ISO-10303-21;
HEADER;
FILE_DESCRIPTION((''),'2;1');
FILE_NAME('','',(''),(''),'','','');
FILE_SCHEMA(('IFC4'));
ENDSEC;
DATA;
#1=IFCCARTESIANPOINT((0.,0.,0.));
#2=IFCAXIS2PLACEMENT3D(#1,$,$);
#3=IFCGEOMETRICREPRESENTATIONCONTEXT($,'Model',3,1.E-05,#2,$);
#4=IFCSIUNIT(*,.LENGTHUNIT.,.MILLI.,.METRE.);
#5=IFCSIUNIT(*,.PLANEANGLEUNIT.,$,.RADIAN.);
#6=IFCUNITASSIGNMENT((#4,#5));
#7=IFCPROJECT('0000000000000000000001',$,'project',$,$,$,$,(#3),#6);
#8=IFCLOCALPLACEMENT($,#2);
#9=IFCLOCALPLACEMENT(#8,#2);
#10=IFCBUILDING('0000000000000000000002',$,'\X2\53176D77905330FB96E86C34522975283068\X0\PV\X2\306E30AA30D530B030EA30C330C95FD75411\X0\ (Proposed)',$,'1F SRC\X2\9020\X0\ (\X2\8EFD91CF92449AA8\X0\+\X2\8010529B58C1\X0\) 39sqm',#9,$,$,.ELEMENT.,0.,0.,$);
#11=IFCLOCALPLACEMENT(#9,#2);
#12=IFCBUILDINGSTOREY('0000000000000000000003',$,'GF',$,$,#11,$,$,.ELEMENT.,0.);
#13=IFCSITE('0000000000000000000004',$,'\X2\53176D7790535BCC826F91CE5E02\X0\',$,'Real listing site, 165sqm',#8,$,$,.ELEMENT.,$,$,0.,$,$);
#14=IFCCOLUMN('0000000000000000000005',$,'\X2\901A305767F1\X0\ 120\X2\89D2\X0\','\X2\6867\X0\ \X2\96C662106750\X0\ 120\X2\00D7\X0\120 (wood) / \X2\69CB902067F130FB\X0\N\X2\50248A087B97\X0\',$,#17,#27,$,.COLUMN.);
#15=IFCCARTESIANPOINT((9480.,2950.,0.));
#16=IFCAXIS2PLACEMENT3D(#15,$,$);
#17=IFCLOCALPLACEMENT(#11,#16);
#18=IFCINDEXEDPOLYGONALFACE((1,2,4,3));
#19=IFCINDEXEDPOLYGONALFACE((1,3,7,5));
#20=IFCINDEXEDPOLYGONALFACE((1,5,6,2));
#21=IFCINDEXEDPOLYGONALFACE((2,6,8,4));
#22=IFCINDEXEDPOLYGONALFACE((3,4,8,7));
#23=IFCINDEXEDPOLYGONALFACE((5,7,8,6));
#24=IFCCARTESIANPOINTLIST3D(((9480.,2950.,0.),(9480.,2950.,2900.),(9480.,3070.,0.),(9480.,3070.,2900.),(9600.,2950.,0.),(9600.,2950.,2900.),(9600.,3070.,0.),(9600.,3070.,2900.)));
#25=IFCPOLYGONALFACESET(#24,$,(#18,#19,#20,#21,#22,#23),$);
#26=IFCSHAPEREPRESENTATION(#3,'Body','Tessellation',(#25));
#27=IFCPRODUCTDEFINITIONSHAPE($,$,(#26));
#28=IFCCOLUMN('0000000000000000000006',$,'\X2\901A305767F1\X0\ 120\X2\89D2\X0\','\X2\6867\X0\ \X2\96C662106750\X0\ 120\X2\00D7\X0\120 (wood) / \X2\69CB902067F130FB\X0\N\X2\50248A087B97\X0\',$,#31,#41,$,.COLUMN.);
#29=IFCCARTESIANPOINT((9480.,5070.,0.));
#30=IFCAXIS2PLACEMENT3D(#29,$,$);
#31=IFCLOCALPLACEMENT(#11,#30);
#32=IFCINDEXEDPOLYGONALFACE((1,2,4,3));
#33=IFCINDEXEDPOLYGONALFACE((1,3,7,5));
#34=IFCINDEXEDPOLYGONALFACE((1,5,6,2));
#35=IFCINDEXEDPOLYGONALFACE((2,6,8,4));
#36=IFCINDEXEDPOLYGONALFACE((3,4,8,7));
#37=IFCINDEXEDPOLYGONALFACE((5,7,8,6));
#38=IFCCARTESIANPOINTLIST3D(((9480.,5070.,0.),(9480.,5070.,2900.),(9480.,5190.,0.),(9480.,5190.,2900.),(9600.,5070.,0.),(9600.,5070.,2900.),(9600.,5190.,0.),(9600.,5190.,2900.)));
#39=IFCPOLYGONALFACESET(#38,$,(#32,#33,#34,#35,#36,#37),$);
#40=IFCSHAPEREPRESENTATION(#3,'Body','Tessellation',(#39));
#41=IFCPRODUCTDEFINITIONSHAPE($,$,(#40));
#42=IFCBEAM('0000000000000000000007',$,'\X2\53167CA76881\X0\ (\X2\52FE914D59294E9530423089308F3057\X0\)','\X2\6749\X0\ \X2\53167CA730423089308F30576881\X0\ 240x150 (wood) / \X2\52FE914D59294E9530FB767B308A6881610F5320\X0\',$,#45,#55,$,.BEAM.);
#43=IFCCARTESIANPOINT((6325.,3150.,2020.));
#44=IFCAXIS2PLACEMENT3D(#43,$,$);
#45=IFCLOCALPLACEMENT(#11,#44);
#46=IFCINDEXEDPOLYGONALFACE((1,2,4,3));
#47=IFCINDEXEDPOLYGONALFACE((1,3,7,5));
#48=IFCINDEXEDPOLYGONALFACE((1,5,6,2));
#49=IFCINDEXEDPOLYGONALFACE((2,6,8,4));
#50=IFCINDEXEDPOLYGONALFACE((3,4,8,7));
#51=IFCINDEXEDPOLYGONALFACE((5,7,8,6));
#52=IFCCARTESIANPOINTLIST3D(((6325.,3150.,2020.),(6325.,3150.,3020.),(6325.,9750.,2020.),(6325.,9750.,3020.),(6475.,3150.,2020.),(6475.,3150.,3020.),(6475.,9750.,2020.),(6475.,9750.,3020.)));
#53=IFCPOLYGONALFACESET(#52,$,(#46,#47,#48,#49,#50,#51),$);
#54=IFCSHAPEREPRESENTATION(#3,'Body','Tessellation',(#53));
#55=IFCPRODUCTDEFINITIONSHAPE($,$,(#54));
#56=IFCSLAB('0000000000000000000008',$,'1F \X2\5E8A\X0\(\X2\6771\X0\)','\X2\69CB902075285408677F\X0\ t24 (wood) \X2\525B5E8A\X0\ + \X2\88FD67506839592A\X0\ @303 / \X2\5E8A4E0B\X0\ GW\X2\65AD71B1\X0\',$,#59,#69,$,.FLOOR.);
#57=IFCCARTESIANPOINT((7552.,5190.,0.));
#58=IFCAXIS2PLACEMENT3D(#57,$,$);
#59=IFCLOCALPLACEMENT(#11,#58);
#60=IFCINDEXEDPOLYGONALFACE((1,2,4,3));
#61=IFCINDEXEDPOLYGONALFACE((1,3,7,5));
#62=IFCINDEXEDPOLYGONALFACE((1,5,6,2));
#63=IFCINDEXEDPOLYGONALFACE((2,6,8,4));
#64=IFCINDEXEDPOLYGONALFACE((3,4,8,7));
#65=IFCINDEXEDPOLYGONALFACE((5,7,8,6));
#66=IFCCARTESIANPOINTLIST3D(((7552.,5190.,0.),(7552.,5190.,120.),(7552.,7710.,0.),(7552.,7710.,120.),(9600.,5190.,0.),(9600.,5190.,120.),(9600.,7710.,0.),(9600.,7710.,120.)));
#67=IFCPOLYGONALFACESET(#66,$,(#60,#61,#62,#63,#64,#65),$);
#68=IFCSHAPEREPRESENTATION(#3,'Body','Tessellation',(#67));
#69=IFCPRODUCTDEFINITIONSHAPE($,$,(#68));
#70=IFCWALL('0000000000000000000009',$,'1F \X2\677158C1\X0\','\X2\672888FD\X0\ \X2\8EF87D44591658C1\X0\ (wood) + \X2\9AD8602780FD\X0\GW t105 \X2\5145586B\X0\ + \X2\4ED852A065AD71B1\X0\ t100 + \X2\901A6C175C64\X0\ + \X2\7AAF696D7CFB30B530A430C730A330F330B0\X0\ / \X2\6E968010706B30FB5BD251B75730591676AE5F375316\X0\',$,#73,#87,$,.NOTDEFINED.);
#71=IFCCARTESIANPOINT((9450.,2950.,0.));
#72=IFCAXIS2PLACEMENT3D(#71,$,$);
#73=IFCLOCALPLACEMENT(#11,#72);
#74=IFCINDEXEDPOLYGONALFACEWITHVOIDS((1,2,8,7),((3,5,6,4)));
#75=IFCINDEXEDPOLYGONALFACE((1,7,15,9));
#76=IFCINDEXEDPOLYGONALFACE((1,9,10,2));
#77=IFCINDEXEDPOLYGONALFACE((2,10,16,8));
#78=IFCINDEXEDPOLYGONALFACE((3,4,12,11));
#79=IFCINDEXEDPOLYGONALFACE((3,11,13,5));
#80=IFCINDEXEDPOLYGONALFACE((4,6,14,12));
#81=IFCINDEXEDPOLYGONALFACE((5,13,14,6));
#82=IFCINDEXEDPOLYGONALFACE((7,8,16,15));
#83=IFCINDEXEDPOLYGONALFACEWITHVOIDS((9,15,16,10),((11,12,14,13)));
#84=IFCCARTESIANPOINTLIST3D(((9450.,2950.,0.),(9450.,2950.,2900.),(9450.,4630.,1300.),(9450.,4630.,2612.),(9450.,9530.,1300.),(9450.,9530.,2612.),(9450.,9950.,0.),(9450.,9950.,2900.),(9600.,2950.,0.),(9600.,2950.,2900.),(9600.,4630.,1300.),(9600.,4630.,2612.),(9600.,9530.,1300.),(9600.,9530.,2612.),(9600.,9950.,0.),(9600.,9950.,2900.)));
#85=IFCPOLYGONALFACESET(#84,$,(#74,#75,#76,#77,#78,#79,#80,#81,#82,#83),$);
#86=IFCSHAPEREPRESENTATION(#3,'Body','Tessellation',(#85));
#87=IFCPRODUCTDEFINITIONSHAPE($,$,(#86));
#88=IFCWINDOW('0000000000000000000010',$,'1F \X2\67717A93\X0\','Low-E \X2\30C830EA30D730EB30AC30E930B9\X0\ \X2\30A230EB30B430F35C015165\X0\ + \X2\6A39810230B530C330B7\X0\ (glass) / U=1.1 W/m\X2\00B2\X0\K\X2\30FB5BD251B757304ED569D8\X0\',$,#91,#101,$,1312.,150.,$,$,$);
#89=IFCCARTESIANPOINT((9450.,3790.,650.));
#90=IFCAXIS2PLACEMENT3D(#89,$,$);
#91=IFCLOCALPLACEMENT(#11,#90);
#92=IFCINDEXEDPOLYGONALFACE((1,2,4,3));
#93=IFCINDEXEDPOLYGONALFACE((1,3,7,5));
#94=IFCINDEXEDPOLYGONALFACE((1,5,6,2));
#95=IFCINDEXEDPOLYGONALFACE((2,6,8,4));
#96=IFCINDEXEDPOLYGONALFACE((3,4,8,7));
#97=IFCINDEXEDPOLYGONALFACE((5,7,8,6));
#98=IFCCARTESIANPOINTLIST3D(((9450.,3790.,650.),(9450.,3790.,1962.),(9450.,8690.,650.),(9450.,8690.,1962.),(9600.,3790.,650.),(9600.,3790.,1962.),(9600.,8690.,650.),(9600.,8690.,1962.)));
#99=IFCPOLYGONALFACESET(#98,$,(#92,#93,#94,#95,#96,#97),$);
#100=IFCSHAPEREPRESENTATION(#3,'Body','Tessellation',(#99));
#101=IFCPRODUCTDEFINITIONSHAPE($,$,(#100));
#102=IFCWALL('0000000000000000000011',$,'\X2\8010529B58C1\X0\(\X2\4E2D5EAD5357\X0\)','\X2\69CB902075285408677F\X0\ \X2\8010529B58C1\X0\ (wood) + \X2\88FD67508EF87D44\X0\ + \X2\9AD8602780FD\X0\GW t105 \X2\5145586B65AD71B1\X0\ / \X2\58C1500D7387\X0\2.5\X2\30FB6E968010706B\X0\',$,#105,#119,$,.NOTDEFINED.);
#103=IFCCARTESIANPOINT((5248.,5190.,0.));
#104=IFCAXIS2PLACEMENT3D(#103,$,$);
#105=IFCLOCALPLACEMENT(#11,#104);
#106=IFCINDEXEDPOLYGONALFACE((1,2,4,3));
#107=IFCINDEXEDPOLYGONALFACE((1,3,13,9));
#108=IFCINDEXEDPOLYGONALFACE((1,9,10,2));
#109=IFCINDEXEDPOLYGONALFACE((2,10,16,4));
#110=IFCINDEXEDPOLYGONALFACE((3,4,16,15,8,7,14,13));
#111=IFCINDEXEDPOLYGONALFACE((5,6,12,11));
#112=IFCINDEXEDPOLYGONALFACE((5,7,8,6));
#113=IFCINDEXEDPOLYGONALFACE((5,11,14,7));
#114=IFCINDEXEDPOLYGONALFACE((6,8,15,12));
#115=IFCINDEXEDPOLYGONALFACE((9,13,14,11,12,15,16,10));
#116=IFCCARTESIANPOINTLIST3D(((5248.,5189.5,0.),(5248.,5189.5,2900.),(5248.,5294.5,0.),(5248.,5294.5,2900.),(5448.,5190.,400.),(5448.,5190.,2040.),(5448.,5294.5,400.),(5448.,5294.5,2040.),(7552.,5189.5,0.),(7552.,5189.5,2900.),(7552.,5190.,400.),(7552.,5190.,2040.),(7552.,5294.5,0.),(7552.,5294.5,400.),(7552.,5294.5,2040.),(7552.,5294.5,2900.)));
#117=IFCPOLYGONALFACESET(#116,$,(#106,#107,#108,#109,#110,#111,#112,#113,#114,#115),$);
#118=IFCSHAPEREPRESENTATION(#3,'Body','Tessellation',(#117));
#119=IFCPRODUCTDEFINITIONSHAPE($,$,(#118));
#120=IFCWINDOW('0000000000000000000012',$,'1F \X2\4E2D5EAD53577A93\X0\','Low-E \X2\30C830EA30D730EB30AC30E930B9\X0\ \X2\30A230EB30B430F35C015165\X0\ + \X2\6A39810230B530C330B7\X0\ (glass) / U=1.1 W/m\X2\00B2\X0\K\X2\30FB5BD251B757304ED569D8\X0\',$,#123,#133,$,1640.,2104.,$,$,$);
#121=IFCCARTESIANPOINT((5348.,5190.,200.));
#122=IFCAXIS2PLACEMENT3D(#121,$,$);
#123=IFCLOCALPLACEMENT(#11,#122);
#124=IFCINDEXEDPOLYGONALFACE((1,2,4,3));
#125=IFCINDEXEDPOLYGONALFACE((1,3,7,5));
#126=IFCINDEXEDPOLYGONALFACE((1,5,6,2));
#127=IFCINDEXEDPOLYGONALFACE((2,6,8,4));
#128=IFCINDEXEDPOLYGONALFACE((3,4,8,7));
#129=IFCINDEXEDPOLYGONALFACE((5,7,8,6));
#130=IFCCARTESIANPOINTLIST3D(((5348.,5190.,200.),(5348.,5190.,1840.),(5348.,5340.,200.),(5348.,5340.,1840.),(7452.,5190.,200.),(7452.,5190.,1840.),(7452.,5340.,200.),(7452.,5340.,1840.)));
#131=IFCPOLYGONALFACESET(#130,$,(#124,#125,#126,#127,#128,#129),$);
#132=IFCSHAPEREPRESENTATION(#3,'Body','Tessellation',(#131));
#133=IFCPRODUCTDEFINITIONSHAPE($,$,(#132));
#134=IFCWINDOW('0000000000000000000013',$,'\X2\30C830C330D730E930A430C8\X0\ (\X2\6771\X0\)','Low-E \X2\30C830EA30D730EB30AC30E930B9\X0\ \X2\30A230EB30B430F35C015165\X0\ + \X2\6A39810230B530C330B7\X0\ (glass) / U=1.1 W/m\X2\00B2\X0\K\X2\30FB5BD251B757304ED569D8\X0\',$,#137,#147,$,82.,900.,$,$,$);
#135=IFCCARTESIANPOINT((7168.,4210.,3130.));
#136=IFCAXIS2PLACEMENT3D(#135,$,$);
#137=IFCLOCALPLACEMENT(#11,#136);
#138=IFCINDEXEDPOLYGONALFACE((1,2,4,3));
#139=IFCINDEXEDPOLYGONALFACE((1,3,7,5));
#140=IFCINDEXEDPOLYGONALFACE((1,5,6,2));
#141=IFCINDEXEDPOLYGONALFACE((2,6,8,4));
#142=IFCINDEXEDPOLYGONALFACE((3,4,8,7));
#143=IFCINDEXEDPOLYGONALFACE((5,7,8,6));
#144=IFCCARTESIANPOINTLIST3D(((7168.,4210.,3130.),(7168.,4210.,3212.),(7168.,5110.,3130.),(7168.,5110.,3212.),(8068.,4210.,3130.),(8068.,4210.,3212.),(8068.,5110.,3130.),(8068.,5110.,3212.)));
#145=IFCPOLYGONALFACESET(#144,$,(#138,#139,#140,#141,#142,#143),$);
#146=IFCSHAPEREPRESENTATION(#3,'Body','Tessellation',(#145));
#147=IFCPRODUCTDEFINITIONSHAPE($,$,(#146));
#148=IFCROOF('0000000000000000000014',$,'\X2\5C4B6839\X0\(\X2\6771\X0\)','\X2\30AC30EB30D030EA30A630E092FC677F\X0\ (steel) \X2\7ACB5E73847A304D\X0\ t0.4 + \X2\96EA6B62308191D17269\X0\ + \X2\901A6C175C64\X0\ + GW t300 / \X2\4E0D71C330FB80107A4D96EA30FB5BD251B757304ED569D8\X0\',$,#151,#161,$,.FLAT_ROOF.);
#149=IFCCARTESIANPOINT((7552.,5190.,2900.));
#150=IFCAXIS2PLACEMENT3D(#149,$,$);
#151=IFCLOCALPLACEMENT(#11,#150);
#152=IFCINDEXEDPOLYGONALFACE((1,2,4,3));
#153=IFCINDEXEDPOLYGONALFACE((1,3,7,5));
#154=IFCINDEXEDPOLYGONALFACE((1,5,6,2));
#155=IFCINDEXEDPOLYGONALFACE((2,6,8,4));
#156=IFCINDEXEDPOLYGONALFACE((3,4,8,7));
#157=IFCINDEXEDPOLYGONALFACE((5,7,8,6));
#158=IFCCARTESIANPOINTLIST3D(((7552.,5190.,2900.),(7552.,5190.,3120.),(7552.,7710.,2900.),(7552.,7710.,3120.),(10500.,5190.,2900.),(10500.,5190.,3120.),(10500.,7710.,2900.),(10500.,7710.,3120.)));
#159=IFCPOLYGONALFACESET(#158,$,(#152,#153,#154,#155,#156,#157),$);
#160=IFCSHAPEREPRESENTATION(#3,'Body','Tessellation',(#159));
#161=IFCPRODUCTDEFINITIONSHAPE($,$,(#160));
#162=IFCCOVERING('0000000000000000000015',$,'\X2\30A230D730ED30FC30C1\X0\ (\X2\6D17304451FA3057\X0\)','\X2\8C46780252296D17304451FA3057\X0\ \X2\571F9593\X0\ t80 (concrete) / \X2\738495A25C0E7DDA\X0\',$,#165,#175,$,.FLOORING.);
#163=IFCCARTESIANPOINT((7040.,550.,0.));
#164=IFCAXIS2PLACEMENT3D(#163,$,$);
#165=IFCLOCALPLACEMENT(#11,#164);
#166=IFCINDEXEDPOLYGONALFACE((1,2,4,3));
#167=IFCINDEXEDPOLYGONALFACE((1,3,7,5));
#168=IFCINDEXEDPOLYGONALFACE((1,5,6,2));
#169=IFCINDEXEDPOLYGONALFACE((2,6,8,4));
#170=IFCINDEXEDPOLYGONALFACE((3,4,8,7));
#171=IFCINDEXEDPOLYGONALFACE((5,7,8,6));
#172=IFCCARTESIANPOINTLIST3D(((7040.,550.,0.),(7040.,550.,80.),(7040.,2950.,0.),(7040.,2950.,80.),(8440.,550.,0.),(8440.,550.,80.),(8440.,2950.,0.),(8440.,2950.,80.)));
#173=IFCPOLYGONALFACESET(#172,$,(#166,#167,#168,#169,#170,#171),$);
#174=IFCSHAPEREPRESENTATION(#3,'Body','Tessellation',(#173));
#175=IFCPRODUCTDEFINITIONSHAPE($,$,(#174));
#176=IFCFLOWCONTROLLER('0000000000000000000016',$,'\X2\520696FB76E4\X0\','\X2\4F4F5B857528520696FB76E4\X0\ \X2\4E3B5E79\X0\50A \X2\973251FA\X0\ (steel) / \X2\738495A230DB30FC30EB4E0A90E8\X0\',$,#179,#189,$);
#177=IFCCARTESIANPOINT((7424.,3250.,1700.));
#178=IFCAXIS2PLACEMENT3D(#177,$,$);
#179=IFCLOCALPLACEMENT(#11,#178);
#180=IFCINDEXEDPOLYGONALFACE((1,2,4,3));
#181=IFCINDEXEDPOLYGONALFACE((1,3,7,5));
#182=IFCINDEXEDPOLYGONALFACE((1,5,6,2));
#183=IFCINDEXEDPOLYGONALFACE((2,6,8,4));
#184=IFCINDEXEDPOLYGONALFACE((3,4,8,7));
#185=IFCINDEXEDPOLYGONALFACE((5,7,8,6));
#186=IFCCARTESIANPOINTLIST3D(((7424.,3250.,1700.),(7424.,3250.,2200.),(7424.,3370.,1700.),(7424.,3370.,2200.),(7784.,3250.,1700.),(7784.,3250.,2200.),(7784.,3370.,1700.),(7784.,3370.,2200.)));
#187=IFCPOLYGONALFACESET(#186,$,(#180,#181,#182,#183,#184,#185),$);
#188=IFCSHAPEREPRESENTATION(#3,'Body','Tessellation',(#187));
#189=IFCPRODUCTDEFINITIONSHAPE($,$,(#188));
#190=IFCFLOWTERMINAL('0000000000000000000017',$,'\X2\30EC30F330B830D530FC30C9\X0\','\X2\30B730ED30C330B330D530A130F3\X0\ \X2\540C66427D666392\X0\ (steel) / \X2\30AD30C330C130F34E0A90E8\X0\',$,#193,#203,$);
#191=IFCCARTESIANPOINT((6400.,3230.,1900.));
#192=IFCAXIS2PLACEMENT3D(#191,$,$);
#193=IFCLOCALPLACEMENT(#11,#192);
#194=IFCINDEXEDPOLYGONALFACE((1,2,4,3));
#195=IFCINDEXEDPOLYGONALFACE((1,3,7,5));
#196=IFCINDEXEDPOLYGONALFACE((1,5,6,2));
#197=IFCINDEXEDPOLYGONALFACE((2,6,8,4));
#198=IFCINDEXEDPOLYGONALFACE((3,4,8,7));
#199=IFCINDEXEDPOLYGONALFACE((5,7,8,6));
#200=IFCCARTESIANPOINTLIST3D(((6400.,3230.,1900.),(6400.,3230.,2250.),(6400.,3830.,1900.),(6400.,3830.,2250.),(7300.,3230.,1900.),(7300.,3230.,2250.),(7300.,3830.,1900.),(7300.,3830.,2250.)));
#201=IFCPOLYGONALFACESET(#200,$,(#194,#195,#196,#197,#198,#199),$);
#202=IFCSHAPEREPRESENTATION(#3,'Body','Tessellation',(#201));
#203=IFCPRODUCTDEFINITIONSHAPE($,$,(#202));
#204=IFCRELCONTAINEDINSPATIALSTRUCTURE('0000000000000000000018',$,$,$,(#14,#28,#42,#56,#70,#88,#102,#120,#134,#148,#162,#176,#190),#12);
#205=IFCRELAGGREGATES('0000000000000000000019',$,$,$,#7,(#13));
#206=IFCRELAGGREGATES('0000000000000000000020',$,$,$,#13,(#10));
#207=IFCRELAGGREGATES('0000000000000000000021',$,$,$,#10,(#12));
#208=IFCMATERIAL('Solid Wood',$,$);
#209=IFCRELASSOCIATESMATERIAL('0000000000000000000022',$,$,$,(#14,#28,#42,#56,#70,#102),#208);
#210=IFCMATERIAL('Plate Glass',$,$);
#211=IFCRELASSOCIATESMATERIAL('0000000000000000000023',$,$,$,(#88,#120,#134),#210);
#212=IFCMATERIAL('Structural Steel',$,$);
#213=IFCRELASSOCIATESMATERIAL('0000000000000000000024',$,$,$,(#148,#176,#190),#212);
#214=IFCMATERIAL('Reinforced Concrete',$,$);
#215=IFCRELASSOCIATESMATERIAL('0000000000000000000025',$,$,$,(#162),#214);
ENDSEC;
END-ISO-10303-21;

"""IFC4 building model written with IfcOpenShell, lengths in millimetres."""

from ifc_helpers import new_model, si_unit, frame, frame_2d, origin, place, context, project, spatial, rectangle, extrude, material, element, fill, save


model = new_model("IFC4")

# Units and contexts
model_context = context("Model", 3, precision=1e-05, world=origin())
ifc_project = project(units=[si_unit("LENGTHUNIT", "METRE", prefix="MILLI"), si_unit("PLANEANGLEUNIT", "RADIAN")], contexts=[model_context])

# Site, building, storey
site_placement = place(None, origin())
site = spatial("IfcSite", under=ifc_project, at=site_placement, Name="北海道富良野市", ObjectType="Real listing site, 165sqm", CompositionType="ELEMENT", RefElevation=0.0)
building_placement = place(site_placement, origin())
building = spatial("IfcBuilding", under=site, at=building_placement, Name="北海道・雨水利用とPVのオフグリッド志向 (Proposed)", ObjectType="1F SRC造 (軽量鉄骨+耐力壁) 39sqm", CompositionType="ELEMENT", ElevationOfRefHeight=0.0, ElevationOfTerrain=0.0)
storey_placement = place(building_placement, origin())
storey = spatial("IfcBuildingStorey", under=building, at=storey_placement, Name="GF", CompositionType="ELEMENT", Elevation=0.0)

# Columns
ifc_material_1 = material(Name="Solid Wood")
column_1_placement = place(storey_placement, frame((9480.0, 2950.0, 0.0)))
element("IfcColumn", 1, at=column_1_placement, inside=storey, material=ifc_material_1, Name="通し柱 120角", Description="桧 集成材 120×120 (wood) / 構造柱・N値計算", PredefinedType="COLUMN", context=model_context, shape_type="SweptSolid", body=[
    extrude(rectangle(XDim=120.0, YDim=120.0, at=frame_2d((60.0, 60.0))), frame((9480.0, 2950.0, 0.0)), (0.0, 0.0, 1.0), 2900.0),
])
column_2_placement = place(storey_placement, frame((9480.0, 5070.0, 0.0)))
element("IfcColumn", 2, at=column_2_placement, inside=storey, material=ifc_material_1, Name="通し柱 120角", Description="桧 集成材 120×120 (wood) / 構造柱・N値計算", PredefinedType="COLUMN", context=model_context, shape_type="SweptSolid", body=[
    extrude(rectangle(XDim=120.0, YDim=120.0, at=frame_2d((60.0, 60.0))), frame((9480.0, 5070.0, 0.0)), (0.0, 0.0, 1.0), 2900.0),
])

# Beam
beam_1_placement = place(storey_placement, frame((6325.0, 3150.0, 2020.0)))
element("IfcBeam", 3, at=beam_1_placement, inside=storey, material=ifc_material_1, Name="化粧梁 (勾配天井あらわし)", Description="杉 化粧あらわし梁 240x150 (wood) / 勾配天井・登り梁意匠", PredefinedType="BEAM", context=model_context, shape_type="SweptSolid", body=[
    extrude(rectangle(XDim=150.0, YDim=6600.0, at=frame_2d((75.0, 3300.0))), frame((6325.0, 3150.0, 2020.0)), (0.0, 0.0, 1.0), 1000.0),
])

# Slab
slab_placement = place(storey_placement, frame((7552.0, 5190.0, 0.0)))
element("IfcSlab", 4, at=slab_placement, inside=storey, material=ifc_material_1, Name="1F 床(東)", Description="構造用合板 t24 (wood) 剛床 + 製材根太 @303 / 床下 GW断熱", PredefinedType="FLOOR", context=model_context, shape_type="SweptSolid", body=[
    extrude(rectangle(XDim=2048.0, YDim=2520.0, at=frame_2d((1024.0, 1260.0))), frame((7552.0, 5190.0, 0.0)), (0.0, 0.0, 1.0), 120.0),
])

# Walls, openings, windows
wall_1_placement = place(storey_placement, frame((9450.0, 2950.0, 0.0)))
wall_1 = element("IfcWall", 5, at=wall_1_placement, inside=storey, material=ifc_material_1, Name="1F 東壁", Description="木製 軸組外壁 (wood) + 高性能GW t105 充填 + 付加断熱 t100 + 通気層 + 窯業系サイディング / 準耐火・寒冷地外皮強化", PredefinedType="NOTDEFINED", context=model_context, shape_type="SweptSolid", body=[
    extrude(rectangle(XDim=150.0, YDim=7000.0, at=frame_2d((75.0, 3500.0))), frame((9450.0, 2950.0, 0.0)), (0.0, 0.0, 1.0), 2900.0),
])
opening_1_placement = place(storey_placement, frame((9450.0, 3790.0, 650.0)))
opening_1 = element("IfcOpeningElement", 6, at=opening_1_placement, cuts=wall_1, PredefinedType="NOTDEFINED", context=model_context, shape_type="SweptSolid", body=[
    extrude(rectangle(XDim=150.0, YDim=4900.0, at=frame_2d((75.0, 2450.0))), frame((9450.0, 3790.0, 650.0)), (0.0, 0.0, 1.0), 1312.0),
])
ifc_material_2 = material(Name="Plate Glass")
window_1_placement = place(storey_placement, frame((9450.0, 3790.0, 650.0)))
window_1 = element("IfcWindow", 7, at=window_1_placement, inside=storey, material=ifc_material_2, Name="1F 東窓", Description="Low-E トリプルガラス アルゴン封入 + 樹脂サッシ (glass) / U=1.1 W/m²K・寒冷地仕様", OverallHeight=1312.0, OverallWidth=150.0, context=model_context, shape_type="SweptSolid", body=[
    extrude(rectangle(XDim=150.0, YDim=4900.0, at=frame_2d((75.0, 2450.0))), frame((9450.0, 3790.0, 650.0)), (0.0, 0.0, 1.0), 1312.0),
])
fill(opening_1, window_1)
wall_2_placement = place(storey_placement, frame((5248.0, 5190.0, 0.0)))
wall_2 = element("IfcWall", 8, at=wall_2_placement, inside=storey, material=ifc_material_1, Name="耐力壁(中庭南)", Description="構造用合板 耐力壁 (wood) + 製材軸組 + 高性能GW t105 充填断熱 / 壁倍率2.5・準耐火", PredefinedType="NOTDEFINED", context=model_context, shape_type="SweptSolid", body=[
    extrude(rectangle(XDim=2304.0, YDim=105.0, at=frame_2d((1152.0, 52.0))), frame((5248.0, 5190.0, 0.0)), (0.0, 0.0, 1.0), 2900.0),
])
opening_2_placement = place(storey_placement, frame((5348.0, 5190.0, 200.0)))
opening_2 = element("IfcOpeningElement", 9, at=opening_2_placement, cuts=wall_2, PredefinedType="NOTDEFINED", context=model_context, shape_type="SweptSolid", body=[
    extrude(rectangle(XDim=2104.0, YDim=150.0, at=frame_2d((1052.0, 75.0))), frame((5348.0, 5190.0, 200.0)), (0.0, 0.0, 1.0), 1640.0),
])
window_2_placement = place(storey_placement, frame((5348.0, 5190.0, 200.0)))
window_2 = element("IfcWindow", 10, at=window_2_placement, inside=storey, material=ifc_material_2, Name="1F 中庭南窓", Description="Low-E トリプルガラス アルゴン封入 + 樹脂サッシ (glass) / U=1.1 W/m²K・寒冷地仕様", OverallHeight=1640.0, OverallWidth=2104.0, context=model_context, shape_type="SweptSolid", body=[
    extrude(rectangle(XDim=2104.0, YDim=150.0, at=frame_2d((1052.0, 75.0))), frame((5348.0, 5190.0, 200.0)), (0.0, 0.0, 1.0), 1640.0),
])
fill(opening_2, window_2)

# Window
window_3_placement = place(storey_placement, frame((7168.0, 4210.0, 3130.0)))
element("IfcWindow", 11, at=window_3_placement, inside=storey, material=ifc_material_2, Name="トップライト (東)", Description="Low-E トリプルガラス アルゴン封入 + 樹脂サッシ (glass) / U=1.1 W/m²K・寒冷地仕様", OverallHeight=82.0, OverallWidth=900.0, context=model_context, shape_type="SweptSolid", body=[
    extrude(rectangle(XDim=900.0, YDim=900.0, at=frame_2d((450.0, 450.0))), frame((7168.0, 4210.0, 3130.0)), (0.0, 0.0, 1.0), 82.0),
])

# Roof
ifc_material_3 = material(Name="Structural Steel")
roof_placement = place(storey_placement, frame((7552.0, 5190.0, 2900.0)))
element("IfcRoof", 12, at=roof_placement, inside=storey, material=ifc_material_3, Name="屋根(東)", Description="ガルバリウム鋼板 (steel) 立平葺き t0.4 + 雪止め金物 + 通気層 + GW t300 / 不燃・耐積雪・寒冷地仕様", PredefinedType="FLAT_ROOF", context=model_context, shape_type="SweptSolid", body=[
    extrude(rectangle(XDim=2948.0, YDim=2520.0, at=frame_2d((1474.0, 1260.0))), frame((7552.0, 5190.0, 2900.0)), (0.0, 0.0, 1.0), 220.0),
])

# Covering
ifc_material_4 = material(Name="Reinforced Concrete")
covering_placement = place(storey_placement, frame((7040.0, 550.0, 0.0)))
element("IfcCovering", 13, at=covering_placement, inside=storey, material=ifc_material_4, Name="アプローチ (洗い出し)", Description="豆砂利洗い出し 土間 t80 (concrete) / 玄関導線", PredefinedType="FLOORING", context=model_context, shape_type="SweptSolid", body=[
    extrude(rectangle(XDim=1400.0, YDim=2400.0, at=frame_2d((700.0, 1200.0))), frame((7040.0, 550.0, 0.0)), (0.0, 0.0, 1.0), 80.0),
])

# Flow controller
flow_controller_placement = place(storey_placement, frame((7424.0, 3250.0, 1700.0)))
element("IfcFlowController", 14, at=flow_controller_placement, inside=storey, material=ifc_material_3, Name="分電盤", Description="住宅用分電盤 主幹50A 露出 (steel) / 玄関ホール上部", context=model_context, shape_type="SweptSolid", body=[
    extrude(rectangle(XDim=360.0, YDim=120.0, at=frame_2d((180.0, 60.0))), frame((7424.0, 3250.0, 1700.0)), (0.0, 0.0, 1.0), 500.0),
])

# Flow terminal
flow_terminal_1_placement = place(storey_placement, frame((6400.0, 3230.0, 1900.0)))
element("IfcFlowTerminal", 15, at=flow_terminal_1_placement, inside=storey, material=ifc_material_3, Name="レンジフード", Description="シロッコファン 同時給排 (steel) / キッチン上部", context=model_context, shape_type="SweptSolid", body=[
    extrude(rectangle(XDim=900.0, YDim=600.0, at=frame_2d((450.0, 300.0))), frame((6400.0, 3230.0, 1900.0)), (0.0, 0.0, 1.0), 350.0),
])

save(model, "model.ifc")
